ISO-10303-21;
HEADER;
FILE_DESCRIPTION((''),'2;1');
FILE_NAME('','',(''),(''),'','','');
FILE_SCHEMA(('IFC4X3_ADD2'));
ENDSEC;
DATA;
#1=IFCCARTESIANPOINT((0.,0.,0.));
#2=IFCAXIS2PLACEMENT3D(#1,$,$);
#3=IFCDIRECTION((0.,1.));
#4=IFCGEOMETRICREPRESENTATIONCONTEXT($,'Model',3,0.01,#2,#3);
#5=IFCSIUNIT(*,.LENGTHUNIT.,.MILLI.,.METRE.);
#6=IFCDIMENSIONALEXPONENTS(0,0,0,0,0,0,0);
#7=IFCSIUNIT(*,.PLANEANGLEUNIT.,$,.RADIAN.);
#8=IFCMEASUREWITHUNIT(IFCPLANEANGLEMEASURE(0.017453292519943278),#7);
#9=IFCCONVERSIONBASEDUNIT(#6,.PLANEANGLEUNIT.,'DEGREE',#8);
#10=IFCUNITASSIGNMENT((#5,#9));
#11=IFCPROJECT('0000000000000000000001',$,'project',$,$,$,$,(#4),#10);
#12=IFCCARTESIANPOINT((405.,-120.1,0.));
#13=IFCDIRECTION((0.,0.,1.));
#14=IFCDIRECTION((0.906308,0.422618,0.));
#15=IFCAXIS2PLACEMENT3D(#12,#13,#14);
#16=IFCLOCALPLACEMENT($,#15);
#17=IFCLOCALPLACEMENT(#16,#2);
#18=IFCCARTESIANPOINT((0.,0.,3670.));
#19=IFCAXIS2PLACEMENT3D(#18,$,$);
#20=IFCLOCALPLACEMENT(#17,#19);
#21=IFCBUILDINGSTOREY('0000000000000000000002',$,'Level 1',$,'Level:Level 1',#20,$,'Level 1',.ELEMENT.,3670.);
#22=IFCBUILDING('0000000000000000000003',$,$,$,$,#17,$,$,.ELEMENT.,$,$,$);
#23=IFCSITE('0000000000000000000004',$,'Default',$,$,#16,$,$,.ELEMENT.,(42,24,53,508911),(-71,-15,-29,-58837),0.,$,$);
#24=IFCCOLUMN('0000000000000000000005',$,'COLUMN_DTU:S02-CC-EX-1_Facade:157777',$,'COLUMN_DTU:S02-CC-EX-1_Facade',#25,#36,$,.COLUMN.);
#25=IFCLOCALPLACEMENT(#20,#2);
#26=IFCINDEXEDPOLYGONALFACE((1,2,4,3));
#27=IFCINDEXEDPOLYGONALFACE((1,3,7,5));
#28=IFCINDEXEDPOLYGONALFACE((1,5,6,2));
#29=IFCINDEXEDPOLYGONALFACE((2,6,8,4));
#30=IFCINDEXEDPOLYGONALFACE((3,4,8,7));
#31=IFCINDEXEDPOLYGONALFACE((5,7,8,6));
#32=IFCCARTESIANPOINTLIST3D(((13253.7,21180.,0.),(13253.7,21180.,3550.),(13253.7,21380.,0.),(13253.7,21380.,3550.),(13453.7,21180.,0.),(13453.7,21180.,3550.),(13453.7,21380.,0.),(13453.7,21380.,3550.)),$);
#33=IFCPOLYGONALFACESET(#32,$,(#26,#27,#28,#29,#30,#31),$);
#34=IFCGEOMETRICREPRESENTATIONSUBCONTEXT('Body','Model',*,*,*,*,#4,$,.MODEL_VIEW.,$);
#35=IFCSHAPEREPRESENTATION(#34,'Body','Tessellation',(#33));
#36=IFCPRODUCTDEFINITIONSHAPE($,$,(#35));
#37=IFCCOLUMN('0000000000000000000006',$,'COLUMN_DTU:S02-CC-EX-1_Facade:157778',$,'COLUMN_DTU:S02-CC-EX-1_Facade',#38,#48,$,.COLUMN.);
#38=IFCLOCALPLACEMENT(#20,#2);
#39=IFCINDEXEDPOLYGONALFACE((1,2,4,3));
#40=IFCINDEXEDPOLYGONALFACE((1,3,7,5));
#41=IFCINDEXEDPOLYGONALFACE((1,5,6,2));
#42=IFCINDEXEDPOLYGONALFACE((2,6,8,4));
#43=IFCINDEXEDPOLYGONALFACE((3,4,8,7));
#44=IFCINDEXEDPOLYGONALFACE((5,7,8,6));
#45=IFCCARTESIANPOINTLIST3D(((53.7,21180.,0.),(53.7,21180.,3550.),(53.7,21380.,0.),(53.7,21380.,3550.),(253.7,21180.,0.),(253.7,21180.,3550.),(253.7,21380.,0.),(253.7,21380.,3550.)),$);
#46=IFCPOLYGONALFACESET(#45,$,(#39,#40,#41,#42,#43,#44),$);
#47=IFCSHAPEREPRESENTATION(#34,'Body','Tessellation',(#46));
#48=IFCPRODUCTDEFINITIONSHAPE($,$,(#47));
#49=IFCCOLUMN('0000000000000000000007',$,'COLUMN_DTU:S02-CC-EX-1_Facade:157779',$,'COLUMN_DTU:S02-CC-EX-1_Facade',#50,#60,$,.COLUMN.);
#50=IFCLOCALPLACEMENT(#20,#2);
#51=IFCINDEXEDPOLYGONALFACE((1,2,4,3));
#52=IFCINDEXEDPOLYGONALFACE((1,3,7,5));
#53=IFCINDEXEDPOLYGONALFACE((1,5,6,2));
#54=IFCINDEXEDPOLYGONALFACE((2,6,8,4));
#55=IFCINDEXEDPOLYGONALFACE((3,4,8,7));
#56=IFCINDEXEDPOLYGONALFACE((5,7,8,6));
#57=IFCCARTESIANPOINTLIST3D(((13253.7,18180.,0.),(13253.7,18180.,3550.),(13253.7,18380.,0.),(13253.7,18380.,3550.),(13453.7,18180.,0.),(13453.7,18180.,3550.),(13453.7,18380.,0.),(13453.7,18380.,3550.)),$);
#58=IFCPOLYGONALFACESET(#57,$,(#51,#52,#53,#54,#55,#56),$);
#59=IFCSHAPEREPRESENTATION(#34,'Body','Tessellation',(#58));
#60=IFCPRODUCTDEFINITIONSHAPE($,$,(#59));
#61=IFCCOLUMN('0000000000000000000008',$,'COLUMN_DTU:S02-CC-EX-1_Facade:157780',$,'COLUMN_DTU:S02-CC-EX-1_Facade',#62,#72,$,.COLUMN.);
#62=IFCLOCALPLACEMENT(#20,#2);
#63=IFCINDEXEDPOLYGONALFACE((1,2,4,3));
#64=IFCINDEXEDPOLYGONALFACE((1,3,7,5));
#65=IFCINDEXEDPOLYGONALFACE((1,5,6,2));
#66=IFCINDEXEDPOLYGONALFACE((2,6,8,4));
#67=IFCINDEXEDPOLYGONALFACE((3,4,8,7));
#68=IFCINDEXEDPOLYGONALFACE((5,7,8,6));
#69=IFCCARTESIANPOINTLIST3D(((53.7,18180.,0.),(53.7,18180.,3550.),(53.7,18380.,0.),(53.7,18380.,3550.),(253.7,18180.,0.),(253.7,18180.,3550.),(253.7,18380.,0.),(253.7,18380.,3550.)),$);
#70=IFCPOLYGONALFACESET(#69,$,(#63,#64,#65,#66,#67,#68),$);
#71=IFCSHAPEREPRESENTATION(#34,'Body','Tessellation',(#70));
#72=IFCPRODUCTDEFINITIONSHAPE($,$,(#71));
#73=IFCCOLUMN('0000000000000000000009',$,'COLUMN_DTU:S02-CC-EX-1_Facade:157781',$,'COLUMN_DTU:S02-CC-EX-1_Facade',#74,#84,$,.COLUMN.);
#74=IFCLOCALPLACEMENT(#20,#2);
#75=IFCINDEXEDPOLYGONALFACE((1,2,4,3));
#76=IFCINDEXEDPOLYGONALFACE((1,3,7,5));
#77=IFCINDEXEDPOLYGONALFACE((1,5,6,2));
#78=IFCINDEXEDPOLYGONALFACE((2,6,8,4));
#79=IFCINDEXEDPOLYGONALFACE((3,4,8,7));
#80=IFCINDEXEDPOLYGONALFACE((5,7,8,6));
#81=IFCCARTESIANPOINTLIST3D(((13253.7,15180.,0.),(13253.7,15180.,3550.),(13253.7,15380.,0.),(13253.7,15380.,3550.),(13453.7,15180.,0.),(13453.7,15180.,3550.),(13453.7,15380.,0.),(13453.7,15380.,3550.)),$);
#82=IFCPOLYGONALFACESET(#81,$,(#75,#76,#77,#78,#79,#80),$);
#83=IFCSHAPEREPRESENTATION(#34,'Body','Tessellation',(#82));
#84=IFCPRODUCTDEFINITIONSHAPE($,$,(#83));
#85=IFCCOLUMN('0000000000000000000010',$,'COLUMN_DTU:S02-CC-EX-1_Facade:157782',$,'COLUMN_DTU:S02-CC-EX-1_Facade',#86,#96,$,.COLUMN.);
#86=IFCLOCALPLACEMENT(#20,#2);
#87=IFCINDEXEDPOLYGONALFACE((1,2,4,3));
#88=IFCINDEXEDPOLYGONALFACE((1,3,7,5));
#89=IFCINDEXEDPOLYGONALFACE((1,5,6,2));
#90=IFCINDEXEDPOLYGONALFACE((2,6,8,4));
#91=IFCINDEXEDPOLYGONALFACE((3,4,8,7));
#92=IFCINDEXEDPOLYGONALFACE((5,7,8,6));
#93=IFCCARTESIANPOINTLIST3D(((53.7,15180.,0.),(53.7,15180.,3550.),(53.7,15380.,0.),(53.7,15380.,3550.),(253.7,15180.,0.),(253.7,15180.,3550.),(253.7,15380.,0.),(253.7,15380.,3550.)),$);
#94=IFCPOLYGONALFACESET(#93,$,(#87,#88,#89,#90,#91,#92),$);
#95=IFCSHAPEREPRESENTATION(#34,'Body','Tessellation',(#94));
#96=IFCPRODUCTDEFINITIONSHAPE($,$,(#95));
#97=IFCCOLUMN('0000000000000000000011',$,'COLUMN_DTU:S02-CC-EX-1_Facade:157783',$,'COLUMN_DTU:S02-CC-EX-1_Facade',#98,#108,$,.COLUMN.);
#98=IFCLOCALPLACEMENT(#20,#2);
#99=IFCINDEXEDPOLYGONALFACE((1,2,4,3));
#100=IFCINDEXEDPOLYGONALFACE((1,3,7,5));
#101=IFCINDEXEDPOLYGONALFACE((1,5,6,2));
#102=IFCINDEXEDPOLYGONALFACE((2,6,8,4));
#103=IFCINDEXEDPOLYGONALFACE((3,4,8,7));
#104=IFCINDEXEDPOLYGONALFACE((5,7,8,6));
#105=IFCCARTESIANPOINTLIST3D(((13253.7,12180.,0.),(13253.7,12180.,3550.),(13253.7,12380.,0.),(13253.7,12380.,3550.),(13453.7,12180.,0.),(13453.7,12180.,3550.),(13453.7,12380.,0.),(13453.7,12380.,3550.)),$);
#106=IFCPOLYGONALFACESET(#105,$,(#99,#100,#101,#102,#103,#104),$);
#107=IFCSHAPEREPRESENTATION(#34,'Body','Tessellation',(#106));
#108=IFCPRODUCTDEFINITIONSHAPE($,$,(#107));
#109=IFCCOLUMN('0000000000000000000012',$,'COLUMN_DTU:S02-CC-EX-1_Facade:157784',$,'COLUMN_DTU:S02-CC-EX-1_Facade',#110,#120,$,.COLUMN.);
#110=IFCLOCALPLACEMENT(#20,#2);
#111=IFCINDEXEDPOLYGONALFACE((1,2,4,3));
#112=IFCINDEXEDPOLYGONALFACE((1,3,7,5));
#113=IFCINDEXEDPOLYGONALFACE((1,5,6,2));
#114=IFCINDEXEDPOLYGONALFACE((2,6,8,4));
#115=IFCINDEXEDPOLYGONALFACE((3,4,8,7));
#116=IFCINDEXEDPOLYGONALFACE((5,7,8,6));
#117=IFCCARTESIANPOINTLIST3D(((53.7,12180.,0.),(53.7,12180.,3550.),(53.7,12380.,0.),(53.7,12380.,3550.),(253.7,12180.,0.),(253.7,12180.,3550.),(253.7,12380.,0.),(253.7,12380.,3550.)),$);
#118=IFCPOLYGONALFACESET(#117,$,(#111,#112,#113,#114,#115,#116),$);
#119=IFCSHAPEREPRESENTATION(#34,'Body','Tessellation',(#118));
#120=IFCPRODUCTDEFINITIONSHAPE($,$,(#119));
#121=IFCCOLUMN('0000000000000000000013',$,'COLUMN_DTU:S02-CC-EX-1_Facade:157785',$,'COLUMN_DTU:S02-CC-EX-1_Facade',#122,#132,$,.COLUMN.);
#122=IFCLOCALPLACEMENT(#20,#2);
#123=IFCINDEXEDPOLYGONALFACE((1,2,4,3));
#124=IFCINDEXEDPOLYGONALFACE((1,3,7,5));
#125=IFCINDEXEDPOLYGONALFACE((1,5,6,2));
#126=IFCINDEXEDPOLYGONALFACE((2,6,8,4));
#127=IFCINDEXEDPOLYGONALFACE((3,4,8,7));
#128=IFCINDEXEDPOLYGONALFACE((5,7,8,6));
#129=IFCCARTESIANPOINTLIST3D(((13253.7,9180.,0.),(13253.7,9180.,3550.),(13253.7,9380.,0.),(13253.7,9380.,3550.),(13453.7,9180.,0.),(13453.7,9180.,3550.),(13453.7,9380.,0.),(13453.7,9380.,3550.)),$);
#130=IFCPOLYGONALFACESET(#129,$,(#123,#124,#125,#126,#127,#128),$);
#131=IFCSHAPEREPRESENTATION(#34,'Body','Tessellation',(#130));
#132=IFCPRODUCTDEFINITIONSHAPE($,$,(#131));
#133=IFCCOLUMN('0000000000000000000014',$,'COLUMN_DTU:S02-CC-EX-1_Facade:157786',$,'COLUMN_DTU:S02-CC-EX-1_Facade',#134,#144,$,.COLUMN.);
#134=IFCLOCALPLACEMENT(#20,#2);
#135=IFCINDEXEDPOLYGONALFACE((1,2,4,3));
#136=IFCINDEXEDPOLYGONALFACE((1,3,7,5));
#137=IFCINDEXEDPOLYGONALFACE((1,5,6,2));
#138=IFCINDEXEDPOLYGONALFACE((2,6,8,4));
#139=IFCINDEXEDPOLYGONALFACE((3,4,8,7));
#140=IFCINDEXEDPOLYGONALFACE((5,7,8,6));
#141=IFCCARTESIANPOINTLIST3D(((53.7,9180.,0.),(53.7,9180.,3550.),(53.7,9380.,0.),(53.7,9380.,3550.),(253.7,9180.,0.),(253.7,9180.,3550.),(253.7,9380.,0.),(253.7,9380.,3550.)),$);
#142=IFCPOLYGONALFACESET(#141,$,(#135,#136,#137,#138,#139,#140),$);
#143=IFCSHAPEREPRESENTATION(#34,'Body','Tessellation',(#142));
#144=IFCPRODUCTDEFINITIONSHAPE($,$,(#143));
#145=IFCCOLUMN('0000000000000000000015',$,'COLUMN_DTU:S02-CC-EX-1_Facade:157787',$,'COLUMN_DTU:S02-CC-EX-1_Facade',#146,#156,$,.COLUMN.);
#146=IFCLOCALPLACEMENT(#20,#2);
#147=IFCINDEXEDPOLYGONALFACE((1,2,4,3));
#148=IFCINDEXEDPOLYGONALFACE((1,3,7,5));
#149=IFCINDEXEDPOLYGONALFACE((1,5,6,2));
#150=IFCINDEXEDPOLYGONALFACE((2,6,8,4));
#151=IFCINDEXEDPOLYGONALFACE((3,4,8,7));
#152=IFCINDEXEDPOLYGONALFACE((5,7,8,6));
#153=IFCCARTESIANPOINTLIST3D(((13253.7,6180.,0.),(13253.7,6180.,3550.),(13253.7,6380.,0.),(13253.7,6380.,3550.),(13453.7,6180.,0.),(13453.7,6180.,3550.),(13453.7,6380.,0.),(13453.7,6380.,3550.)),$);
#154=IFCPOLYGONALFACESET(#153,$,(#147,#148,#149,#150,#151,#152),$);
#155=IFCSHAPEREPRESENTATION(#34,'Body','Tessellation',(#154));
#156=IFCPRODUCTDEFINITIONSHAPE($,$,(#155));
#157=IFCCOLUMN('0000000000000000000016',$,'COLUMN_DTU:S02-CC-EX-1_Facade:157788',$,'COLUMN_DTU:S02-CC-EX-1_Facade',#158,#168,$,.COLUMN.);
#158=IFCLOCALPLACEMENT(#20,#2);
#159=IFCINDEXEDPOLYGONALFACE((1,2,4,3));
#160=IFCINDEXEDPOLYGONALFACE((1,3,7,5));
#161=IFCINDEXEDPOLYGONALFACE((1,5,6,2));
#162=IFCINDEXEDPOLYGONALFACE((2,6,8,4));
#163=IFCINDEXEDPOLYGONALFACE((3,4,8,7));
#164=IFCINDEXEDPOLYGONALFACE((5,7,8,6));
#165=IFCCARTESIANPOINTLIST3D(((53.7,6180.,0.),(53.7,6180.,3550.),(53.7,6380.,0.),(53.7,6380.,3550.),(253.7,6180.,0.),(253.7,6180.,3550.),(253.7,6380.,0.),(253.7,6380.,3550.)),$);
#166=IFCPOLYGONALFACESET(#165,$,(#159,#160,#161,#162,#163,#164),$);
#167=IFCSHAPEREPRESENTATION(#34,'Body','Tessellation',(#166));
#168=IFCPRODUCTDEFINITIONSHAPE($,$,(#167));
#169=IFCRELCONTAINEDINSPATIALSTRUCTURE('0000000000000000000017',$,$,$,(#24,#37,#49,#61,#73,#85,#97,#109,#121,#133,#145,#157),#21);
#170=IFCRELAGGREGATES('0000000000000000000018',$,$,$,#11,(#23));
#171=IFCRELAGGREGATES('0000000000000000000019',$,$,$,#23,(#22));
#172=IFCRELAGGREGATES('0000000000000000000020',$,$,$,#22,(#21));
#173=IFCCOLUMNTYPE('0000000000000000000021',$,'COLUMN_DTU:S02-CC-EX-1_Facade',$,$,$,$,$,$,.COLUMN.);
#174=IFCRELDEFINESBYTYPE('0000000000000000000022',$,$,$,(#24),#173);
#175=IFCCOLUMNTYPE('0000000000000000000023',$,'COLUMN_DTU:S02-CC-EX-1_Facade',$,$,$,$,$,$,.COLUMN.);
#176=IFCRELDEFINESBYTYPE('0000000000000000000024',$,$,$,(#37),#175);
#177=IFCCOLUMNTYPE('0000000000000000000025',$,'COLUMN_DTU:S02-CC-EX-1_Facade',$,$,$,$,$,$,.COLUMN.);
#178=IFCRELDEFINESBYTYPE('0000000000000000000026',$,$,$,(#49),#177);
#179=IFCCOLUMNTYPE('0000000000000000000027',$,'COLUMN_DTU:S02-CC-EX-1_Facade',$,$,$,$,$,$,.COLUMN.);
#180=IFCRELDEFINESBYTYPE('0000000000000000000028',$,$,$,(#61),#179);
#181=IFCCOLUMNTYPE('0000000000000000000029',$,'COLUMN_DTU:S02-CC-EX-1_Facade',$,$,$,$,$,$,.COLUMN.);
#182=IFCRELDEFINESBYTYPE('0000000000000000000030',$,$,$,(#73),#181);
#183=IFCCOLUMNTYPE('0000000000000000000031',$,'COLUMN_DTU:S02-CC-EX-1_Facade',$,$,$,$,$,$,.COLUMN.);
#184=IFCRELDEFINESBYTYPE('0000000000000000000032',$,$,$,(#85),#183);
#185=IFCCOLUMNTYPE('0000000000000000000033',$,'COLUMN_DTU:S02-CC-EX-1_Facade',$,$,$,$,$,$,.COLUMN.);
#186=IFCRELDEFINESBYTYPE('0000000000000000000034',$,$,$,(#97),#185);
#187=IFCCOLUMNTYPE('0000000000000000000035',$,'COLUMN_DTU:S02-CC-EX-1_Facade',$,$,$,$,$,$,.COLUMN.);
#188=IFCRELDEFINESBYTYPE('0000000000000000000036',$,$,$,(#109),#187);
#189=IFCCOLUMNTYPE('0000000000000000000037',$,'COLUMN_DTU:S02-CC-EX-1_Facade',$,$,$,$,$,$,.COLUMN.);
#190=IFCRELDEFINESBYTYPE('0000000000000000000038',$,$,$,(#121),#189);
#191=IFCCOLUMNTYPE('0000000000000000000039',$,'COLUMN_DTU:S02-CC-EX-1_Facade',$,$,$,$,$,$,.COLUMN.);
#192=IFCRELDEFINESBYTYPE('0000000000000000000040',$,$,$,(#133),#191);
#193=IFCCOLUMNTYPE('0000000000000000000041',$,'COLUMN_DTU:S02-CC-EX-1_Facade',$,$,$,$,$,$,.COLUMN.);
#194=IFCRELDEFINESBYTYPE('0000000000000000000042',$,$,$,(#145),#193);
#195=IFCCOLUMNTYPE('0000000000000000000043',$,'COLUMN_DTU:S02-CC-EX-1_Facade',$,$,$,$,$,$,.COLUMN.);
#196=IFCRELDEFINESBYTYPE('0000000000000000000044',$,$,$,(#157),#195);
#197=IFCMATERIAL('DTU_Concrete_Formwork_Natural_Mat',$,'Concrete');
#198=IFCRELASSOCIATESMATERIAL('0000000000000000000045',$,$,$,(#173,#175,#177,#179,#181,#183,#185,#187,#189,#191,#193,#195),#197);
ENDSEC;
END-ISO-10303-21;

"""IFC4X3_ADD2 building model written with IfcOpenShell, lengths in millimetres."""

from ifc_helpers import new_model, entity, si_unit, converted_unit, direction, frame, frame_2d, origin, place, context, subcontext, project, spatial, rectangle, extrude, source, transform, mapped, material, material_profile, profile_set, type_object, type_shapes, element, save


model = new_model("IFC4X3_ADD2")

# Units and contexts
model_context = context("Model", 3, precision=0.01, world=origin(), true_north=direction((0.0, 1.0)))
body_context = subcontext(model_context, "Body", "Model", "MODEL_VIEW")
ifc_project = project(units=[si_unit("LENGTHUNIT", "METRE", prefix="MILLI"), converted_unit("PLANEANGLEUNIT", "DEGREE", entity("IfcPlaneAngleMeasure", 0.017453292519943278), si_unit("PLANEANGLEUNIT", "RADIAN"), dimensions=[0, 0, 0, 0, 0, 0, 0])], contexts=[model_context])

# Site, building, storey
site_placement = place(None, frame((405.0, -120.1, 0.0), z_axis=(0.0, 0.0, 1.0), x_axis=(0.906308, 0.422618, 0.0)))
site = spatial("IfcSite", under=ifc_project, at=site_placement, Name="Default", CompositionType="ELEMENT", RefLatitude=(42, 24, 53, 508911), RefLongitude=(-71, -15, -29, -58837), RefElevation=0.0)
building_placement = place(site_placement, origin())
building = spatial("IfcBuilding", under=site, at=building_placement, CompositionType="ELEMENT")
storey_placement = place(building_placement, frame((0.0, 0.0, 3670.0)))
storey = spatial("IfcBuildingStorey", under=building, at=storey_placement, Name="Level 1", ObjectType="Level:Level 1", LongName="Level 1", CompositionType="ELEMENT", Elevation=3670.0)

# Columns
ifc_material = material(Name="DTU_Concrete_Formwork_Natural_Mat", Category="Concrete")
ifc_material_profile_1 = material_profile(ifc_material, rectangle(XDim=200.0, YDim=200.0, at=frame_2d((0.0, 0.0), x_axis=(1.0, 0.0))), Name="S02-CC-EX-1_Facade")
ifc_profile_set_1 = profile_set([ifc_material_profile_1], Name="S02-CC-EX-1_Facade")
column_type_1 = type_object("IfcColumnType", Name="COLUMN_DTU:S02-CC-EX-1_Facade", PredefinedType="COLUMN", material=ifc_profile_set_1)
shared_shape_1 = source(origin(), body_context, "Body", "SweptSolid", [
    extrude(rectangle(XDim=200.0, YDim=200.0, at=frame_2d((0.0, 0.0), x_axis=(1.0, 0.0))), frame((13353.7, 21280.0, 3670.0), z_axis=(0.0, 0.0, 1.0), x_axis=(0.0, 1.0, 0.0)), (0.0, 0.0, 1.0), 3550.0),
])
type_shapes(column_type_1, [shared_shape_1])
column_1_placement = place(storey_placement, frame((0.0, 0.0, -3670.0)))
element("IfcColumn", 1, at=column_1_placement, inside=storey, type_object=column_type_1, Name="COLUMN_DTU:S02-CC-EX-1_Facade:157777", ObjectType="COLUMN_DTU:S02-CC-EX-1_Facade", PredefinedType="COLUMN", context=body_context, shape_type="MappedRepresentation", body=[
    mapped(shared_shape_1, transform((0.0, 0.0, 0.0), scale=1.0)),
])
column_type_2 = type_object("IfcColumnType", Name="COLUMN_DTU:S02-CC-EX-1_Facade", PredefinedType="COLUMN", material=ifc_profile_set_1)
shared_shape_2 = source(origin(), body_context, "Body", "SweptSolid", [
    extrude(rectangle(XDim=200.0, YDim=200.0, at=frame_2d((0.0, 0.0), x_axis=(1.0, 0.0))), frame((153.7, 21280.0, 3670.0), z_axis=(0.0, 0.0, 1.0), x_axis=(0.0, 1.0, 0.0)), (0.0, 0.0, 1.0), 3550.0),
])
type_shapes(column_type_2, [shared_shape_2])
column_2_placement = place(storey_placement, frame((0.0, 0.0, -3670.0)))
element("IfcColumn", 2, at=column_2_placement, inside=storey, type_object=column_type_2, Name="COLUMN_DTU:S02-CC-EX-1_Facade:157778", ObjectType="COLUMN_DTU:S02-CC-EX-1_Facade", PredefinedType="COLUMN", context=body_context, shape_type="MappedRepresentation", body=[
    mapped(shared_shape_2, transform((0.0, 0.0, 0.0), scale=1.0)),
])
column_type_3 = type_object("IfcColumnType", Name="COLUMN_DTU:S02-CC-EX-1_Facade", PredefinedType="COLUMN", material=ifc_profile_set_1)
shared_shape_3 = source(origin(), body_context, "Body", "SweptSolid", [
    extrude(rectangle(XDim=200.0, YDim=200.0, at=frame_2d((0.0, 0.0), x_axis=(1.0, 0.0))), frame((13353.7, 18280.0, 3670.0), z_axis=(0.0, 0.0, 1.0), x_axis=(0.0, 1.0, 0.0)), (0.0, 0.0, 1.0), 3550.0),
])
type_shapes(column_type_3, [shared_shape_3])
column_3_placement = place(storey_placement, frame((0.0, 0.0, -3670.0)))
element("IfcColumn", 3, at=column_3_placement, inside=storey, type_object=column_type_3, Name="COLUMN_DTU:S02-CC-EX-1_Facade:157779", ObjectType="COLUMN_DTU:S02-CC-EX-1_Facade", PredefinedType="COLUMN", context=body_context, shape_type="MappedRepresentation", body=[
    mapped(shared_shape_3, transform((0.0, 0.0, 0.0), scale=1.0)),
])
column_type_4 = type_object("IfcColumnType", Name="COLUMN_DTU:S02-CC-EX-1_Facade", PredefinedType="COLUMN", material=ifc_profile_set_1)
shared_shape_4 = source(origin(), body_context, "Body", "SweptSolid", [
    extrude(rectangle(XDim=200.0, YDim=200.0, at=frame_2d((0.0, 0.0), x_axis=(1.0, 0.0))), frame((153.7, 18280.0, 3670.0), z_axis=(0.0, 0.0, 1.0), x_axis=(0.0, 1.0, 0.0)), (0.0, 0.0, 1.0), 3550.0),
])
type_shapes(column_type_4, [shared_shape_4])
column_4_placement = place(storey_placement, frame((0.0, 0.0, -3670.0)))
element("IfcColumn", 4, at=column_4_placement, inside=storey, type_object=column_type_4, Name="COLUMN_DTU:S02-CC-EX-1_Facade:157780", ObjectType="COLUMN_DTU:S02-CC-EX-1_Facade", PredefinedType="COLUMN", context=body_context, shape_type="MappedRepresentation", body=[
    mapped(shared_shape_4, transform((0.0, 0.0, 0.0), scale=1.0)),
])
column_type_5 = type_object("IfcColumnType", Name="COLUMN_DTU:S02-CC-EX-1_Facade", PredefinedType="COLUMN", material=ifc_profile_set_1)
shared_shape_5 = source(origin(), body_context, "Body", "SweptSolid", [
    extrude(rectangle(XDim=200.0, YDim=200.0, at=frame_2d((0.0, 0.0), x_axis=(1.0, 0.0))), frame((13353.7, 15280.0, 3670.0), z_axis=(0.0, 0.0, 1.0), x_axis=(0.0, 1.0, 0.0)), (0.0, 0.0, 1.0), 3550.0),
])
type_shapes(column_type_5, [shared_shape_5])
column_5_placement = place(storey_placement, frame((0.0, 0.0, -3670.0)))
element("IfcColumn", 5, at=column_5_placement, inside=storey, type_object=column_type_5, Name="COLUMN_DTU:S02-CC-EX-1_Facade:157781", ObjectType="COLUMN_DTU:S02-CC-EX-1_Facade", PredefinedType="COLUMN", context=body_context, shape_type="MappedRepresentation", body=[
    mapped(shared_shape_5, transform((0.0, 0.0, 0.0), scale=1.0)),
])
column_type_6 = type_object("IfcColumnType", Name="COLUMN_DTU:S02-CC-EX-1_Facade", PredefinedType="COLUMN", material=ifc_profile_set_1)
shared_shape_6 = source(origin(), body_context, "Body", "SweptSolid", [
    extrude(rectangle(XDim=200.0, YDim=200.0, at=frame_2d((0.0, 0.0), x_axis=(1.0, 0.0))), frame((153.7, 15280.0, 3670.0), z_axis=(0.0, 0.0, 1.0), x_axis=(0.0, 1.0, 0.0)), (0.0, 0.0, 1.0), 3550.0),
])
type_shapes(column_type_6, [shared_shape_6])
column_6_placement = place(storey_placement, frame((0.0, 0.0, -3670.0)))
element("IfcColumn", 6, at=column_6_placement, inside=storey, type_object=column_type_6, Name="COLUMN_DTU:S02-CC-EX-1_Facade:157782", ObjectType="COLUMN_DTU:S02-CC-EX-1_Facade", PredefinedType="COLUMN", context=body_context, shape_type="MappedRepresentation", body=[
    mapped(shared_shape_6, transform((0.0, 0.0, 0.0), scale=1.0)),
])
column_type_7 = type_object("IfcColumnType", Name="COLUMN_DTU:S02-CC-EX-1_Facade", PredefinedType="COLUMN", material=ifc_profile_set_1)
shared_shape_7 = source(origin(), body_context, "Body", "SweptSolid", [
    extrude(rectangle(XDim=200.0, YDim=200.0, at=frame_2d((0.0, 0.0), x_axis=(1.0, 0.0))), frame((13353.7, 12280.0, 3670.0), z_axis=(0.0, 0.0, 1.0), x_axis=(0.0, 1.0, 0.0)), (0.0, 0.0, 1.0), 3550.0),
])
type_shapes(column_type_7, [shared_shape_7])
column_7_placement = place(storey_placement, frame((0.0, 0.0, -3670.0)))
element("IfcColumn", 7, at=column_7_placement, inside=storey, type_object=column_type_7, Name="COLUMN_DTU:S02-CC-EX-1_Facade:157783", ObjectType="COLUMN_DTU:S02-CC-EX-1_Facade", PredefinedType="COLUMN", context=body_context, shape_type="MappedRepresentation", body=[
    mapped(shared_shape_7, transform((0.0, 0.0, 0.0), scale=1.0)),
])
column_type_8 = type_object("IfcColumnType", Name="COLUMN_DTU:S02-CC-EX-1_Facade", PredefinedType="COLUMN", material=ifc_profile_set_1)
shared_shape_8 = source(origin(), body_context, "Body", "SweptSolid", [
    extrude(rectangle(XDim=200.0, YDim=200.0, at=frame_2d((0.0, 0.0), x_axis=(1.0, 0.0))), frame((153.7, 12280.0, 3670.0), z_axis=(0.0, 0.0, 1.0), x_axis=(0.0, 1.0, 0.0)), (0.0, 0.0, 1.0), 3550.0),
])
type_shapes(column_type_8, [shared_shape_8])
column_8_placement = place(storey_placement, frame((0.0, 0.0, -3670.0)))
element("IfcColumn", 8, at=column_8_placement, inside=storey, type_object=column_type_8, Name="COLUMN_DTU:S02-CC-EX-1_Facade:157784", ObjectType="COLUMN_DTU:S02-CC-EX-1_Facade", PredefinedType="COLUMN", context=body_context, shape_type="MappedRepresentation", body=[
    mapped(shared_shape_8, transform((0.0, 0.0, 0.0), scale=1.0)),
])
column_type_9 = type_object("IfcColumnType", Name="COLUMN_DTU:S02-CC-EX-1_Facade", PredefinedType="COLUMN", material=ifc_profile_set_1)
shared_shape_9 = source(origin(), body_context, "Body", "SweptSolid", [
    extrude(rectangle(XDim=200.0, YDim=200.0, at=frame_2d((0.0, 0.0), x_axis=(1.0, 0.0))), frame((13353.7, 9280.0, 3670.0), z_axis=(0.0, 0.0, 1.0), x_axis=(0.0, 1.0, 0.0)), (0.0, 0.0, 1.0), 3550.0),
])
type_shapes(column_type_9, [shared_shape_9])
column_9_placement = place(storey_placement, frame((0.0, 0.0, -3670.0)))
element("IfcColumn", 9, at=column_9_placement, inside=storey, type_object=column_type_9, Name="COLUMN_DTU:S02-CC-EX-1_Facade:157785", ObjectType="COLUMN_DTU:S02-CC-EX-1_Facade", PredefinedType="COLUMN", context=body_context, shape_type="MappedRepresentation", body=[
    mapped(shared_shape_9, transform((0.0, 0.0, 0.0), scale=1.0)),
])
column_type_10 = type_object("IfcColumnType", Name="COLUMN_DTU:S02-CC-EX-1_Facade", PredefinedType="COLUMN", material=ifc_profile_set_1)
shared_shape_10 = source(origin(), body_context, "Body", "SweptSolid", [
    extrude(rectangle(XDim=200.0, YDim=200.0, at=frame_2d((0.0, 0.0), x_axis=(1.0, 0.0))), frame((153.7, 9280.0, 3670.0), z_axis=(0.0, 0.0, 1.0), x_axis=(0.0, 1.0, 0.0)), (0.0, 0.0, 1.0), 3550.0),
])
type_shapes(column_type_10, [shared_shape_10])
column_10_placement = place(storey_placement, frame((0.0, 0.0, -3670.0)))
element("IfcColumn", 10, at=column_10_placement, inside=storey, type_object=column_type_10, Name="COLUMN_DTU:S02-CC-EX-1_Facade:157786", ObjectType="COLUMN_DTU:S02-CC-EX-1_Facade", PredefinedType="COLUMN", context=body_context, shape_type="MappedRepresentation", body=[
    mapped(shared_shape_10, transform((0.0, 0.0, 0.0), scale=1.0)),
])
column_type_11 = type_object("IfcColumnType", Name="COLUMN_DTU:S02-CC-EX-1_Facade", PredefinedType="COLUMN", material=ifc_profile_set_1)
shared_shape_11 = source(origin(), body_context, "Body", "SweptSolid", [
    extrude(rectangle(XDim=200.0, YDim=200.0, at=frame_2d((0.0, 0.0), x_axis=(1.0, 0.0))), frame((13353.7, 6280.0, 3670.0), z_axis=(0.0, 0.0, 1.0), x_axis=(0.0, 1.0, 0.0)), (0.0, 0.0, 1.0), 3550.0),
])
type_shapes(column_type_11, [shared_shape_11])
column_11_placement = place(storey_placement, frame((0.0, 0.0, -3670.0)))
element("IfcColumn", 11, at=column_11_placement, inside=storey, type_object=column_type_11, Name="COLUMN_DTU:S02-CC-EX-1_Facade:157787", ObjectType="COLUMN_DTU:S02-CC-EX-1_Facade", PredefinedType="COLUMN", context=body_context, shape_type="MappedRepresentation", body=[
    mapped(shared_shape_11, transform((0.0, 0.0, 0.0), scale=1.0)),
])
column_type_12 = type_object("IfcColumnType", Name="COLUMN_DTU:S02-CC-EX-1_Facade", PredefinedType="COLUMN", material=ifc_profile_set_1)
shared_shape_12 = source(origin(), body_context, "Body", "SweptSolid", [
    extrude(rectangle(XDim=200.0, YDim=200.0, at=frame_2d((0.0, 0.0), x_axis=(1.0, 0.0))), frame((153.7, 6280.0, 3670.0), z_axis=(0.0, 0.0, 1.0), x_axis=(0.0, 1.0, 0.0)), (0.0, 0.0, 1.0), 3550.0),
])
type_shapes(column_type_12, [shared_shape_12])
column_12_placement = place(storey_placement, frame((0.0, 0.0, -3670.0)))
element("IfcColumn", 12, at=column_12_placement, inside=storey, type_object=column_type_12, Name="COLUMN_DTU:S02-CC-EX-1_Facade:157788", ObjectType="COLUMN_DTU:S02-CC-EX-1_Facade", PredefinedType="COLUMN", context=body_context, shape_type="MappedRepresentation", body=[
    mapped(shared_shape_12, transform((0.0, 0.0, 0.0), scale=1.0)),
])

save(model, "model.ifc")
